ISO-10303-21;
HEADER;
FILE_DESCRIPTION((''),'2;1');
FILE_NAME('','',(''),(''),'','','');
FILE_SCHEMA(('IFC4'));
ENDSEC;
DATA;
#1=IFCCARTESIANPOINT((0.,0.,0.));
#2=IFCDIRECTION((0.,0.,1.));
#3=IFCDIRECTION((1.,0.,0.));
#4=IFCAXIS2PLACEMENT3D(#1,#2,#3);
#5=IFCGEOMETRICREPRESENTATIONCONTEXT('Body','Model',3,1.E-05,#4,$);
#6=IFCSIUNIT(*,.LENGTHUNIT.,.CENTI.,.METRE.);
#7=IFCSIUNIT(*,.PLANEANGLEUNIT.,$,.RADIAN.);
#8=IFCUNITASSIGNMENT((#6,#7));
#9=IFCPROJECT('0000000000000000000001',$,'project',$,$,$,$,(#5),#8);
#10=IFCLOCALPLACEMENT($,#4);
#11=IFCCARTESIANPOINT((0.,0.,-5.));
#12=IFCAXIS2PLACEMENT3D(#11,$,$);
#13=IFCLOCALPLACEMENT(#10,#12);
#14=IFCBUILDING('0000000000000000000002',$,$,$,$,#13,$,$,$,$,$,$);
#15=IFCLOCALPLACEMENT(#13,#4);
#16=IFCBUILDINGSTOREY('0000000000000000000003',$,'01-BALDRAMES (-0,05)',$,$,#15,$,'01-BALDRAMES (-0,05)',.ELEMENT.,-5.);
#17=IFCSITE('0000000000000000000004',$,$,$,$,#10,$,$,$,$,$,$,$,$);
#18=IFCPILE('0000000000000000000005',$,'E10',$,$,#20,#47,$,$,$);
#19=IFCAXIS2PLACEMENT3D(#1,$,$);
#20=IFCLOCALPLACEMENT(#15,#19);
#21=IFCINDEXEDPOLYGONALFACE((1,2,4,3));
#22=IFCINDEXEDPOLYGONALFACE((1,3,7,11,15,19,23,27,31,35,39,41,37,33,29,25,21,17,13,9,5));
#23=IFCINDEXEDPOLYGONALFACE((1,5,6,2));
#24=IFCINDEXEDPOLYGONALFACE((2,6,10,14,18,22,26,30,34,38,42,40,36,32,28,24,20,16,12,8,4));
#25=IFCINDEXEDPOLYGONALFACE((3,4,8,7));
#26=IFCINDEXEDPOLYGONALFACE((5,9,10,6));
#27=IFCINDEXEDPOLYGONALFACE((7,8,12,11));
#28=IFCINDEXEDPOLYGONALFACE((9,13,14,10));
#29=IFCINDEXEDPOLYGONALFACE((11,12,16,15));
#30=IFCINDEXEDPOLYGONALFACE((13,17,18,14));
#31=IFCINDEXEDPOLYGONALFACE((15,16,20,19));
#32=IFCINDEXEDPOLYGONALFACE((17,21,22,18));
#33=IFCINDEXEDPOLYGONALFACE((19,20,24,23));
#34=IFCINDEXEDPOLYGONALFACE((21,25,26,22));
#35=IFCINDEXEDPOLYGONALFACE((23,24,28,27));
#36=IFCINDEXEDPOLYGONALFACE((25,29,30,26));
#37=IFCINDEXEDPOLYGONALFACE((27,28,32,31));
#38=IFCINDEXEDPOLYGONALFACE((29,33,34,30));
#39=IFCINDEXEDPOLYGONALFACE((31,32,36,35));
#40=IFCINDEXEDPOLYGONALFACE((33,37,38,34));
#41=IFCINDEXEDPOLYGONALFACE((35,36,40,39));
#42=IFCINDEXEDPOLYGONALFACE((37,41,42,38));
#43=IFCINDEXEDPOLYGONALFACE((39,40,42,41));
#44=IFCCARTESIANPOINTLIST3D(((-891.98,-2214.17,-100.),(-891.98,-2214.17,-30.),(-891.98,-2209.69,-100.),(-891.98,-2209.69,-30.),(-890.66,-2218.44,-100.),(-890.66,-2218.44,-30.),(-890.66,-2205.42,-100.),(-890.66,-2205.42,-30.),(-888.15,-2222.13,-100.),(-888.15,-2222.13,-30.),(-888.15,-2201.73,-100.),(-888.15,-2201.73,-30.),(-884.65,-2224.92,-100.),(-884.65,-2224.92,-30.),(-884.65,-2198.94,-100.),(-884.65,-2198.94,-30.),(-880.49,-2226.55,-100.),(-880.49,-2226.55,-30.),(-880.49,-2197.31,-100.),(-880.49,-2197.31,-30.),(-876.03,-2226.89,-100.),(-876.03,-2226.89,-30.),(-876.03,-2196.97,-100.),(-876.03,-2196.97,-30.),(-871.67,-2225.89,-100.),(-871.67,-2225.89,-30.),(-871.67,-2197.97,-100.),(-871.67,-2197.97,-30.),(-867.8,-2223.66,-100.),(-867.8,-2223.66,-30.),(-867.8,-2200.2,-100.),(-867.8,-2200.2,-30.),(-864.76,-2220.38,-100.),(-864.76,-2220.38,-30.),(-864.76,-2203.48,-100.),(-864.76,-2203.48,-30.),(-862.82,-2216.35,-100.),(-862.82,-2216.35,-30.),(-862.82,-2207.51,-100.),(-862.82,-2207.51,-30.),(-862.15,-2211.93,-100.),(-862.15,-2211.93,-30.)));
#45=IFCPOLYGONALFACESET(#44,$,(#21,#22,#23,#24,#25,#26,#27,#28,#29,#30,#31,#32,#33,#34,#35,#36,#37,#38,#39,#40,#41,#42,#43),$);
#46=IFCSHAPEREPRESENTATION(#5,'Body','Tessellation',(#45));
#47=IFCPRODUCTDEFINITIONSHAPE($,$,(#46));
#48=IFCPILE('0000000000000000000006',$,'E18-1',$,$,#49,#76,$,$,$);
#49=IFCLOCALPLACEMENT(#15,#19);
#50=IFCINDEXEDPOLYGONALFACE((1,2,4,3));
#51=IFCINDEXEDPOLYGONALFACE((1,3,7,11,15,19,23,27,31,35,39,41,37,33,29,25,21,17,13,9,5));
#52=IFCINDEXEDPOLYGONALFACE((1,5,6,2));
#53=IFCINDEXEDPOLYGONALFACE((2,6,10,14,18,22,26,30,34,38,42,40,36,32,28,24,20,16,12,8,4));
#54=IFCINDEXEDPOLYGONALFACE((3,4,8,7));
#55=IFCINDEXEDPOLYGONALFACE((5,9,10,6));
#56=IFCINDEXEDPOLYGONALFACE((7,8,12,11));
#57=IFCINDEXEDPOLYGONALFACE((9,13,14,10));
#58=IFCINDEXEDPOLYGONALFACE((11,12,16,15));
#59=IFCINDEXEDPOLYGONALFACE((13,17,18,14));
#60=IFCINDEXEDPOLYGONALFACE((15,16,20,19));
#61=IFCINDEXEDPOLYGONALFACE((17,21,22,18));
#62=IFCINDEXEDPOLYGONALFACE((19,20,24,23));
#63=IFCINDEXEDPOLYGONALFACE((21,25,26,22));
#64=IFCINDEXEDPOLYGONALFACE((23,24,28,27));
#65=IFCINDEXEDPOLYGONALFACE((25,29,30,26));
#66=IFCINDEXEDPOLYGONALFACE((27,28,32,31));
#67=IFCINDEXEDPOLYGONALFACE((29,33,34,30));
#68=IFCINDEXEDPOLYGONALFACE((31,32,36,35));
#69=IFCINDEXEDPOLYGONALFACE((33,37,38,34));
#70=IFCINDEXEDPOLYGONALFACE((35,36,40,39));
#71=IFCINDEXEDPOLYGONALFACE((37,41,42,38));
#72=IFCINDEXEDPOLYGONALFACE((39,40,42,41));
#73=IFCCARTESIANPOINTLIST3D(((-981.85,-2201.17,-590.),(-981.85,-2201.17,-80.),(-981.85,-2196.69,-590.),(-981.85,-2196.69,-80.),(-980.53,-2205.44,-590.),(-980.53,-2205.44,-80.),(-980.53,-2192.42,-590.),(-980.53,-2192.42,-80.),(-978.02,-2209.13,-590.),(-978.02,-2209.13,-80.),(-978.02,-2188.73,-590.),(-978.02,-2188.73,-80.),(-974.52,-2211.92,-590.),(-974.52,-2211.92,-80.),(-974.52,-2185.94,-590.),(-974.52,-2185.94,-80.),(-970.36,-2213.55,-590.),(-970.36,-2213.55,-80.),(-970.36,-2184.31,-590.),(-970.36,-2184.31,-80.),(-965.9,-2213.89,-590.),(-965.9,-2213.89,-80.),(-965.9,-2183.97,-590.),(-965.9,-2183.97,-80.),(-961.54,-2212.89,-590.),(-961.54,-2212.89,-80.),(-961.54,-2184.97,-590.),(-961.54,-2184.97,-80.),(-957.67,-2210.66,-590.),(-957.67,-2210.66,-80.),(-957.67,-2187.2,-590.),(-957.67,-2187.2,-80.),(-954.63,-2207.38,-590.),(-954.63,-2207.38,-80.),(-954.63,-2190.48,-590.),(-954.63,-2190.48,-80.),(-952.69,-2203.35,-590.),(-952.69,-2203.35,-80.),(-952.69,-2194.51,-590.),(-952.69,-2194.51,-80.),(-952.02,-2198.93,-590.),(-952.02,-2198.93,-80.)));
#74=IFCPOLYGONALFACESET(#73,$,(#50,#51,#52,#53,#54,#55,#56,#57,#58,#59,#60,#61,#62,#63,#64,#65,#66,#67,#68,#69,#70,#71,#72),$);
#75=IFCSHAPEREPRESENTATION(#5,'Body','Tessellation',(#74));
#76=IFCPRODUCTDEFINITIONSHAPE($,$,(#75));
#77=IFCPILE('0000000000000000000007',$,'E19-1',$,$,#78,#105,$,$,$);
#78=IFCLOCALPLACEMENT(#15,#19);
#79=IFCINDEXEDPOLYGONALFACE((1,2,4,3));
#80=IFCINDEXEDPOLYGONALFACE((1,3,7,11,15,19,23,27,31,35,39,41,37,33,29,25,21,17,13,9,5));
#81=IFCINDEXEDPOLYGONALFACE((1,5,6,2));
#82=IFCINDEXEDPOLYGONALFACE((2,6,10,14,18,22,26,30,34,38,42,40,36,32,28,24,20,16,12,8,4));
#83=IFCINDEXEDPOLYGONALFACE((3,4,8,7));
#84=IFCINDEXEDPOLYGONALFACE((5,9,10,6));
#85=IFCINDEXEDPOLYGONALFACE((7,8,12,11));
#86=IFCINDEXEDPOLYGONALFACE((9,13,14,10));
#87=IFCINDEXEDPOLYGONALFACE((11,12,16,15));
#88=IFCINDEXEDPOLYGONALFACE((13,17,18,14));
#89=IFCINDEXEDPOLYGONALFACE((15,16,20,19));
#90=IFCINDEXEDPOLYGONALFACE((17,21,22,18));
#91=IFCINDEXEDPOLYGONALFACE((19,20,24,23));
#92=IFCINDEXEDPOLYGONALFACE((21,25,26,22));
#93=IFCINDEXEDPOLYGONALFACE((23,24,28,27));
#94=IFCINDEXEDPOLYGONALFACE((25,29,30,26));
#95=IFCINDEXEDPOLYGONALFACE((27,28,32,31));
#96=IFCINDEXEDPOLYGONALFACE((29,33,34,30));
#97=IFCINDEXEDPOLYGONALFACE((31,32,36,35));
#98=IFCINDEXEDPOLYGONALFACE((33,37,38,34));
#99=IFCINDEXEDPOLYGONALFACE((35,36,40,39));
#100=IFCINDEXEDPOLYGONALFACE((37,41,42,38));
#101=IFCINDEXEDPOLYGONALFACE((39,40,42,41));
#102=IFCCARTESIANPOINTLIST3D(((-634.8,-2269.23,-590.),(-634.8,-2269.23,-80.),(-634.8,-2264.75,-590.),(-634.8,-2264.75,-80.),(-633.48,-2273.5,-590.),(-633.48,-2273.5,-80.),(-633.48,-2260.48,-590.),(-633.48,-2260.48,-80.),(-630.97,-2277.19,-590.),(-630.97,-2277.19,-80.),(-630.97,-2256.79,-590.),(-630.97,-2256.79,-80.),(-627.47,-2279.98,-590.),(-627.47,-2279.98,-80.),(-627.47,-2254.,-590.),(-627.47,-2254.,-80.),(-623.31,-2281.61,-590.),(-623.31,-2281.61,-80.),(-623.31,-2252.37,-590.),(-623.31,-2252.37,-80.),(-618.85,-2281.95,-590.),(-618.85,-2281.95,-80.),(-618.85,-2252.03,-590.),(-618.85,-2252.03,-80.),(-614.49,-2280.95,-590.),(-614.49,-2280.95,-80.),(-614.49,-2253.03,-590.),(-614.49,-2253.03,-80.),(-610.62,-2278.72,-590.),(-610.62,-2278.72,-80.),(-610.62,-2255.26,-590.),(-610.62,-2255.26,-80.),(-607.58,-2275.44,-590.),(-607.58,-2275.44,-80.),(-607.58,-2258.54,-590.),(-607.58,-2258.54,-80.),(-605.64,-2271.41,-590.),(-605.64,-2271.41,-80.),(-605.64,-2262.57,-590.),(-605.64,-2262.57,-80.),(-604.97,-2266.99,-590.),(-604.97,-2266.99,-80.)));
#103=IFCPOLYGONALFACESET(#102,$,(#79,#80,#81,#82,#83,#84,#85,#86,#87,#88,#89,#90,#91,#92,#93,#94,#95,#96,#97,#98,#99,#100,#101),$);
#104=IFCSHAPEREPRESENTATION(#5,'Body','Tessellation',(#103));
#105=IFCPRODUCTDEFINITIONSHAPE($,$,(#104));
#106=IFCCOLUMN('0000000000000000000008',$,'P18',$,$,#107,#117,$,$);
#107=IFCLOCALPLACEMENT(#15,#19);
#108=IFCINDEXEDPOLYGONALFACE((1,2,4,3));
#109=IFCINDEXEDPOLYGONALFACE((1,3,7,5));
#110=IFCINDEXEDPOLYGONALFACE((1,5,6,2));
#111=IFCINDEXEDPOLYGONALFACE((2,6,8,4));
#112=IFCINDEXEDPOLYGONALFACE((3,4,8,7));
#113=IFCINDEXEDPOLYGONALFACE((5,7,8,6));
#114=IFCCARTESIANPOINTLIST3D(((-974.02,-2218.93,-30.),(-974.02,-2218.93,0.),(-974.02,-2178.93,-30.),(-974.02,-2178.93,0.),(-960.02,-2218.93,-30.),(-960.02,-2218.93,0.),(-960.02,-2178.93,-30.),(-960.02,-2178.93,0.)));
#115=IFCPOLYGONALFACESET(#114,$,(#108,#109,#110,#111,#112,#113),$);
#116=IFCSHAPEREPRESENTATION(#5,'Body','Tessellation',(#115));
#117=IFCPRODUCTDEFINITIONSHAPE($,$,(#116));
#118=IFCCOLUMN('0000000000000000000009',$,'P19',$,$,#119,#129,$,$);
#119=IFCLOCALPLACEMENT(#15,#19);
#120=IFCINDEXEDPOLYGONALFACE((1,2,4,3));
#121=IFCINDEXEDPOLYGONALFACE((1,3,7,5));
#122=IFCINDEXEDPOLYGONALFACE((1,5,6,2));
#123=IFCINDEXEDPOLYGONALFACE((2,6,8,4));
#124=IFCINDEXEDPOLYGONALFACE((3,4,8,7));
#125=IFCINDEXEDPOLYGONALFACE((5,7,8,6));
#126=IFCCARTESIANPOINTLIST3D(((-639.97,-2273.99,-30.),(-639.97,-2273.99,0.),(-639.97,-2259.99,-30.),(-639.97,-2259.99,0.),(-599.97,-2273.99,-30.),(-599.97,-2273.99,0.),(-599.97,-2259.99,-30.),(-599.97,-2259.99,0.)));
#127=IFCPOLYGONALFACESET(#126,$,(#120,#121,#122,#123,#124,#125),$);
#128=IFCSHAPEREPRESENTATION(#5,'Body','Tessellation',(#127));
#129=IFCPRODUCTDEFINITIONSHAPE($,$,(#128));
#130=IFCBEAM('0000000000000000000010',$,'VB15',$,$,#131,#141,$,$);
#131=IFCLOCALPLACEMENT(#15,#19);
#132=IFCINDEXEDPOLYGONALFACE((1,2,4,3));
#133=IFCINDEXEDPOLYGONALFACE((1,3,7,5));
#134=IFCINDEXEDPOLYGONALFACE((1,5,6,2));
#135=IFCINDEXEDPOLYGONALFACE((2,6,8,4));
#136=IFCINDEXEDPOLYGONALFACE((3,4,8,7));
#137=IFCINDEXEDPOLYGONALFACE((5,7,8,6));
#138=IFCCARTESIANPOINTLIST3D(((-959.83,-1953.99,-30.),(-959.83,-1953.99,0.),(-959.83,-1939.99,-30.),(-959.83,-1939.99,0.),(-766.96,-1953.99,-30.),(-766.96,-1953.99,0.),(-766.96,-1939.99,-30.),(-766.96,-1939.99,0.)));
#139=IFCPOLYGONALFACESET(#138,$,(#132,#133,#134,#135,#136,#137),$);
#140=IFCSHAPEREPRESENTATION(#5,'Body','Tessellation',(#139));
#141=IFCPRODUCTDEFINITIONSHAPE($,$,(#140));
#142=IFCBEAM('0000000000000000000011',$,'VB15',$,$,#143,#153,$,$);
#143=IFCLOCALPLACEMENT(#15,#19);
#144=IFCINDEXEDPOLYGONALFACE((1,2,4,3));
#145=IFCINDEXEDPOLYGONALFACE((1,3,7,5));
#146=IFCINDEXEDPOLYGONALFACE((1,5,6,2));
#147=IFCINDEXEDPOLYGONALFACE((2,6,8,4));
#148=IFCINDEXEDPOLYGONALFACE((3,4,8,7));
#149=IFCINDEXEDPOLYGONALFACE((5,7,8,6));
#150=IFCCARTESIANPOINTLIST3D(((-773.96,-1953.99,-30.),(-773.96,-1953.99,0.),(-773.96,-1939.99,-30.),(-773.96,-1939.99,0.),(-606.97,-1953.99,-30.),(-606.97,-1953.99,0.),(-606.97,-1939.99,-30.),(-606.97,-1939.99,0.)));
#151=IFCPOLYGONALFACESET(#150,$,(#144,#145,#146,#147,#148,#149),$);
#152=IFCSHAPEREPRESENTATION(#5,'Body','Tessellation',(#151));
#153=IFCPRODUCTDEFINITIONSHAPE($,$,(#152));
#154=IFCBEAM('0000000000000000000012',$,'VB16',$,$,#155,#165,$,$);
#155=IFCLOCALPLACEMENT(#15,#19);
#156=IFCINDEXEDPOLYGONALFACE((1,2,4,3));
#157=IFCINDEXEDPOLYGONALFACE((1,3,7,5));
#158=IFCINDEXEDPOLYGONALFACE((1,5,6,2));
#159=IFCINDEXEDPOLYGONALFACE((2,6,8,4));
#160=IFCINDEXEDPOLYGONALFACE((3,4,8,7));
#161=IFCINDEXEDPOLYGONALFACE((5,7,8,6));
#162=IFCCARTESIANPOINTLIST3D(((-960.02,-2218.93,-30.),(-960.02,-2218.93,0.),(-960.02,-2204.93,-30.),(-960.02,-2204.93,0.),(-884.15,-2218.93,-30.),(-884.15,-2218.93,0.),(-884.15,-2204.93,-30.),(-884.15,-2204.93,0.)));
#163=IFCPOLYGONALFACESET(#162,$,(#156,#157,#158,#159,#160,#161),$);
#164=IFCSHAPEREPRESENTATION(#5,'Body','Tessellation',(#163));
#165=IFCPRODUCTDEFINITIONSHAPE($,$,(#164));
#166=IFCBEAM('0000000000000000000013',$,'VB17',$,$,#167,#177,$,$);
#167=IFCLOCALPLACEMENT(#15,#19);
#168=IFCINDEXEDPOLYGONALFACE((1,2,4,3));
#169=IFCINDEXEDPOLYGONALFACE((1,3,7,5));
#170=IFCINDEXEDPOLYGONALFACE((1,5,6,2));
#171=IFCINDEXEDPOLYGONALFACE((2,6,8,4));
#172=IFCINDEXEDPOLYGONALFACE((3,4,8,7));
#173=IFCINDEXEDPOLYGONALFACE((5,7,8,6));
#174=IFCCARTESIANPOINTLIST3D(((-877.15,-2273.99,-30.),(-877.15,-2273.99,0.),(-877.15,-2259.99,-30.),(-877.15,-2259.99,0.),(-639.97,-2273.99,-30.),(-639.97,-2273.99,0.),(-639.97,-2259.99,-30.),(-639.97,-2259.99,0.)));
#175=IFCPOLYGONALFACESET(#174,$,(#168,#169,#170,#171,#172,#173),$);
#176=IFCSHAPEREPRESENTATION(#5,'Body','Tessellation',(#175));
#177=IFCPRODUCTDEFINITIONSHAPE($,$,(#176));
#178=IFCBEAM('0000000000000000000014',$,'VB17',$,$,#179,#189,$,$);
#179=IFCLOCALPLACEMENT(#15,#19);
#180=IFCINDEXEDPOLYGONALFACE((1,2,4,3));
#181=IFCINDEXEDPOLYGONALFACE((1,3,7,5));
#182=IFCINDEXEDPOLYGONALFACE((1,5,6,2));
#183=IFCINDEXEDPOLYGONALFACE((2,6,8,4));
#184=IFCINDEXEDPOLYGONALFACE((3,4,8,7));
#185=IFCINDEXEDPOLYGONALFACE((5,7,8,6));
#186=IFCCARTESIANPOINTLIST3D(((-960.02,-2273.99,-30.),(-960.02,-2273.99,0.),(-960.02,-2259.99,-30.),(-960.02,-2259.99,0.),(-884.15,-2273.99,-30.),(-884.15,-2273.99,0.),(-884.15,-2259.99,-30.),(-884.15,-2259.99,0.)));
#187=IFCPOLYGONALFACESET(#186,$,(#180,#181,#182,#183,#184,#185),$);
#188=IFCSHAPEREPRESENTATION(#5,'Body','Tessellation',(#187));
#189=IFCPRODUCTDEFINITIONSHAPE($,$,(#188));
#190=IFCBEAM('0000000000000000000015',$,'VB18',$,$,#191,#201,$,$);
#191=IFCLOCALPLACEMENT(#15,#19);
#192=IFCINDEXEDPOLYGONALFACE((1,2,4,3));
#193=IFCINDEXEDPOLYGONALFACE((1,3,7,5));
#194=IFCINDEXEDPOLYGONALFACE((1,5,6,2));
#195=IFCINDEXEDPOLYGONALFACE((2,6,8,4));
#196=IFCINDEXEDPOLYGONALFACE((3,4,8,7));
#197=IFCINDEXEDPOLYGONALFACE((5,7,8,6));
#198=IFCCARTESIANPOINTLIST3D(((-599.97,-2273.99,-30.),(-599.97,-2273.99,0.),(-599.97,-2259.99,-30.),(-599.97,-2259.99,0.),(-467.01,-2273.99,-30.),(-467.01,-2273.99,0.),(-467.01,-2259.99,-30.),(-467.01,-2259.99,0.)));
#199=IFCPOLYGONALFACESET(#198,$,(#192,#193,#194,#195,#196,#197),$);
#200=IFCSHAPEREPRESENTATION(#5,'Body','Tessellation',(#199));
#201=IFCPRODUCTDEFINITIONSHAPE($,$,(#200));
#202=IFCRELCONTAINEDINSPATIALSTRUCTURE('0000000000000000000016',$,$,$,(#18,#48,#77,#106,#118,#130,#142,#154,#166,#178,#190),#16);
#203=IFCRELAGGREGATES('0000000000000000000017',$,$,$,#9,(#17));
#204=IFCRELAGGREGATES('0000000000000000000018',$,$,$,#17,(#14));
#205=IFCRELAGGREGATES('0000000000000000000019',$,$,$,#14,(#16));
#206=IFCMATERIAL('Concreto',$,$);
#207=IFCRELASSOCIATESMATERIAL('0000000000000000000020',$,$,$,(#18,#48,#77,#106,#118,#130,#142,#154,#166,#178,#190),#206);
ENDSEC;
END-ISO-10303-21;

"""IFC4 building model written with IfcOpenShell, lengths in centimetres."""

from ifc_helpers import new_model, si_unit, frame, origin_with_axes, origin_2d_with_axis, place, context, project, spatial, rectangle, circle, extrude, material, element, save


model = new_model("IFC4")

# Units and contexts
model_context = context("Model", 3, precision=1e-05, world=origin_with_axes(), identifier="Body")
ifc_project = project(units=[si_unit("LENGTHUNIT", "METRE", prefix="CENTI"), si_unit("PLANEANGLEUNIT", "RADIAN")], contexts=[model_context])

# Site, building, storey
site_placement = place(None, origin_with_axes())
site = spatial("IfcSite", under=ifc_project, at=site_placement)
building_placement = place(site_placement, frame((0.0, 0.0, -5.0)))
building = spatial("IfcBuilding", under=site, at=building_placement)
storey_placement = place(building_placement, origin_with_axes())
storey = spatial("IfcBuildingStorey", under=building, at=storey_placement, Name="01-BALDRAMES (-0,05)", LongName="01-BALDRAMES (-0,05)", CompositionType="ELEMENT", Elevation=-5.0)

# Piles
ifc_material = material(Name="Concreto")
pile_placement = place(storey_placement, frame((-877.15, -2211.93, -30.0), z_axis=(0.0, 0.0, 1.0), x_axis=(1.0, 0.0, 0.0)))
element("IfcPile", 1, at=pile_placement, inside=storey, material=ifc_material, Name="E10", context=model_context, shape_type="SolidModel", body=[
    extrude(circle(Radius=15.0, at=origin_2d_with_axis()), frame((0.0, 0.0, -70.0), z_axis=(0.0, 0.0, 1.0), x_axis=(1.0, 0.0, 0.0)), (0.0, 0.0, 1.0), 70.0),
])
for number, where, z_axis, x_axis, name in (
    (2, (-967.02, -2198.93, -80.0), (0.0, 0.0, 1.0), (1.0, 0.0, 0.0), "E18-1"),
    (3, (-619.97, -2266.99, -80.0), (0.0, 0.0, 1.0), (1.0, 0.0, 0.0), "E19-1"),
):
    element("IfcPile", number, at=place(storey_placement, frame(where, z_axis=z_axis, x_axis=x_axis)), inside=storey, material=ifc_material, Name=name, context=model_context, shape_type="SweptSolid", body=[
        extrude(circle(Radius=15.0, at=origin_2d_with_axis()), frame((0.0, 0.0, -510.0), z_axis=(0.0, 0.0, 1.0), x_axis=(1.0, 0.0, 0.0)), (0.0, 0.0, 1.0), 510.0),
    ])

# Columns
column_1_placement = place(storey_placement, frame((-967.02, -2198.93, 0.0), z_axis=(0.0, 0.0, 1.0), x_axis=(1.0, 0.0, 0.0)))
element("IfcColumn", 4, at=column_1_placement, inside=storey, material=ifc_material, Name="P18", context=model_context, shape_type="SolidModel", body=[
    extrude(rectangle(XDim=14.0, YDim=40.0, at=origin_2d_with_axis()), origin_with_axes(), (0.0, 0.0, -1.0), 30.0),
])
column_2_placement = place(storey_placement, frame((-619.97, -2266.99, 0.0), z_axis=(0.0, 0.0, 1.0), x_axis=(1.0, 0.0, 0.0)))
element("IfcColumn", 5, at=column_2_placement, inside=storey, material=ifc_material, Name="P19", context=model_context, shape_type="SolidModel", body=[
    extrude(rectangle(XDim=14.0, YDim=40.0, at=origin_2d_with_axis()), frame((0.0, 0.0, 0.0), z_axis=(0.0, 0.0, 1.0), x_axis=(0.0, 1.0, 0.0)), (0.0, 0.0, -1.0), 30.0),
])

# Beams
beam_1_placement = place(storey_placement, frame((-863.39, -1946.99, 0.0), z_axis=(0.0, 0.0, 1.0), x_axis=(1.0, 0.0, 0.0)))
element("IfcBeam", 6, at=beam_1_placement, inside=storey, material=ifc_material, Name="VB15", context=model_context, shape_type="SolidModel", body=[
    extrude(rectangle(XDim=14.0, YDim=30.0, at=origin_2d_with_axis()), frame((-96.44, 0.0, -15.0), z_axis=(1.0, 0.0, 0.0), x_axis=(0.0, -1.0, 0.0)), (0.0, 0.0, 1.0), 192.87),
])
beam_2_placement = place(storey_placement, frame((-690.47, -1946.99, 0.0), z_axis=(0.0, 0.0, 1.0), x_axis=(1.0, 0.0, 0.0)))
element("IfcBeam", 7, at=beam_2_placement, inside=storey, material=ifc_material, Name="VB15", context=model_context, shape_type="SolidModel", body=[
    extrude(rectangle(XDim=14.0, YDim=30.0, at=origin_2d_with_axis()), frame((-83.5, 0.0, -15.0), z_axis=(1.0, 0.0, 0.0), x_axis=(0.0, -1.0, 0.0)), (0.0, 0.0, 1.0), 166.99),
])
beam_3_placement = place(storey_placement, frame((-922.09, -2211.93, 0.0), z_axis=(0.0, 0.0, 1.0), x_axis=(1.0, 0.0, 0.0)))
element("IfcBeam", 8, at=beam_3_placement, inside=storey, material=ifc_material, Name="VB16", context=model_context, shape_type="SolidModel", body=[
    extrude(rectangle(XDim=14.0, YDim=30.0, at=origin_2d_with_axis()), frame((-37.94, 0.0, -15.0), z_axis=(1.0, 0.0, 0.0), x_axis=(0.0, -1.0, 0.0)), (0.0, 0.0, 1.0), 75.87),
])
beam_4_placement = place(storey_placement, frame((-758.56, -2266.99, 0.0), z_axis=(0.0, 0.0, 1.0), x_axis=(1.0, 0.0, 0.0)))
element("IfcBeam", 9, at=beam_4_placement, inside=storey, material=ifc_material, Name="VB17", context=model_context, shape_type="SolidModel", body=[
    extrude(rectangle(XDim=14.0, YDim=30.0, at=origin_2d_with_axis()), frame((-118.59, 0.0, -15.0), z_axis=(1.0, 0.0, 0.0), x_axis=(0.0, -1.0, 0.0)), (0.0, 0.0, 1.0), 237.18),
])
beam_5_placement = place(storey_placement, frame((-922.09, -2266.99, 0.0), z_axis=(0.0, 0.0, 1.0), x_axis=(1.0, 0.0, 0.0)))
element("IfcBeam", 10, at=beam_5_placement, inside=storey, material=ifc_material, Name="VB17", context=model_context, shape_type="SolidModel", body=[
    extrude(rectangle(XDim=14.0, YDim=30.0, at=origin_2d_with_axis()), frame((-37.94, 0.0, -15.0), z_axis=(1.0, 0.0, 0.0), x_axis=(0.0, -1.0, 0.0)), (0.0, 0.0, 1.0), 75.87),
])
beam_6_placement = place(storey_placement, frame((-533.49, -2266.99, 0.0), z_axis=(0.0, 0.0, 1.0), x_axis=(1.0, 0.0, 0.0)))
element("IfcBeam", 11, at=beam_6_placement, inside=storey, material=ifc_material, Name="VB18", context=model_context, shape_type="SolidModel", body=[
    extrude(rectangle(XDim=14.0, YDim=30.0, at=origin_2d_with_axis()), frame((-66.48, 0.0, -15.0), z_axis=(1.0, 0.0, 0.0), x_axis=(0.0, -1.0, 0.0)), (0.0, 0.0, 1.0), 132.96),
])

save(model, "model.ifc")
